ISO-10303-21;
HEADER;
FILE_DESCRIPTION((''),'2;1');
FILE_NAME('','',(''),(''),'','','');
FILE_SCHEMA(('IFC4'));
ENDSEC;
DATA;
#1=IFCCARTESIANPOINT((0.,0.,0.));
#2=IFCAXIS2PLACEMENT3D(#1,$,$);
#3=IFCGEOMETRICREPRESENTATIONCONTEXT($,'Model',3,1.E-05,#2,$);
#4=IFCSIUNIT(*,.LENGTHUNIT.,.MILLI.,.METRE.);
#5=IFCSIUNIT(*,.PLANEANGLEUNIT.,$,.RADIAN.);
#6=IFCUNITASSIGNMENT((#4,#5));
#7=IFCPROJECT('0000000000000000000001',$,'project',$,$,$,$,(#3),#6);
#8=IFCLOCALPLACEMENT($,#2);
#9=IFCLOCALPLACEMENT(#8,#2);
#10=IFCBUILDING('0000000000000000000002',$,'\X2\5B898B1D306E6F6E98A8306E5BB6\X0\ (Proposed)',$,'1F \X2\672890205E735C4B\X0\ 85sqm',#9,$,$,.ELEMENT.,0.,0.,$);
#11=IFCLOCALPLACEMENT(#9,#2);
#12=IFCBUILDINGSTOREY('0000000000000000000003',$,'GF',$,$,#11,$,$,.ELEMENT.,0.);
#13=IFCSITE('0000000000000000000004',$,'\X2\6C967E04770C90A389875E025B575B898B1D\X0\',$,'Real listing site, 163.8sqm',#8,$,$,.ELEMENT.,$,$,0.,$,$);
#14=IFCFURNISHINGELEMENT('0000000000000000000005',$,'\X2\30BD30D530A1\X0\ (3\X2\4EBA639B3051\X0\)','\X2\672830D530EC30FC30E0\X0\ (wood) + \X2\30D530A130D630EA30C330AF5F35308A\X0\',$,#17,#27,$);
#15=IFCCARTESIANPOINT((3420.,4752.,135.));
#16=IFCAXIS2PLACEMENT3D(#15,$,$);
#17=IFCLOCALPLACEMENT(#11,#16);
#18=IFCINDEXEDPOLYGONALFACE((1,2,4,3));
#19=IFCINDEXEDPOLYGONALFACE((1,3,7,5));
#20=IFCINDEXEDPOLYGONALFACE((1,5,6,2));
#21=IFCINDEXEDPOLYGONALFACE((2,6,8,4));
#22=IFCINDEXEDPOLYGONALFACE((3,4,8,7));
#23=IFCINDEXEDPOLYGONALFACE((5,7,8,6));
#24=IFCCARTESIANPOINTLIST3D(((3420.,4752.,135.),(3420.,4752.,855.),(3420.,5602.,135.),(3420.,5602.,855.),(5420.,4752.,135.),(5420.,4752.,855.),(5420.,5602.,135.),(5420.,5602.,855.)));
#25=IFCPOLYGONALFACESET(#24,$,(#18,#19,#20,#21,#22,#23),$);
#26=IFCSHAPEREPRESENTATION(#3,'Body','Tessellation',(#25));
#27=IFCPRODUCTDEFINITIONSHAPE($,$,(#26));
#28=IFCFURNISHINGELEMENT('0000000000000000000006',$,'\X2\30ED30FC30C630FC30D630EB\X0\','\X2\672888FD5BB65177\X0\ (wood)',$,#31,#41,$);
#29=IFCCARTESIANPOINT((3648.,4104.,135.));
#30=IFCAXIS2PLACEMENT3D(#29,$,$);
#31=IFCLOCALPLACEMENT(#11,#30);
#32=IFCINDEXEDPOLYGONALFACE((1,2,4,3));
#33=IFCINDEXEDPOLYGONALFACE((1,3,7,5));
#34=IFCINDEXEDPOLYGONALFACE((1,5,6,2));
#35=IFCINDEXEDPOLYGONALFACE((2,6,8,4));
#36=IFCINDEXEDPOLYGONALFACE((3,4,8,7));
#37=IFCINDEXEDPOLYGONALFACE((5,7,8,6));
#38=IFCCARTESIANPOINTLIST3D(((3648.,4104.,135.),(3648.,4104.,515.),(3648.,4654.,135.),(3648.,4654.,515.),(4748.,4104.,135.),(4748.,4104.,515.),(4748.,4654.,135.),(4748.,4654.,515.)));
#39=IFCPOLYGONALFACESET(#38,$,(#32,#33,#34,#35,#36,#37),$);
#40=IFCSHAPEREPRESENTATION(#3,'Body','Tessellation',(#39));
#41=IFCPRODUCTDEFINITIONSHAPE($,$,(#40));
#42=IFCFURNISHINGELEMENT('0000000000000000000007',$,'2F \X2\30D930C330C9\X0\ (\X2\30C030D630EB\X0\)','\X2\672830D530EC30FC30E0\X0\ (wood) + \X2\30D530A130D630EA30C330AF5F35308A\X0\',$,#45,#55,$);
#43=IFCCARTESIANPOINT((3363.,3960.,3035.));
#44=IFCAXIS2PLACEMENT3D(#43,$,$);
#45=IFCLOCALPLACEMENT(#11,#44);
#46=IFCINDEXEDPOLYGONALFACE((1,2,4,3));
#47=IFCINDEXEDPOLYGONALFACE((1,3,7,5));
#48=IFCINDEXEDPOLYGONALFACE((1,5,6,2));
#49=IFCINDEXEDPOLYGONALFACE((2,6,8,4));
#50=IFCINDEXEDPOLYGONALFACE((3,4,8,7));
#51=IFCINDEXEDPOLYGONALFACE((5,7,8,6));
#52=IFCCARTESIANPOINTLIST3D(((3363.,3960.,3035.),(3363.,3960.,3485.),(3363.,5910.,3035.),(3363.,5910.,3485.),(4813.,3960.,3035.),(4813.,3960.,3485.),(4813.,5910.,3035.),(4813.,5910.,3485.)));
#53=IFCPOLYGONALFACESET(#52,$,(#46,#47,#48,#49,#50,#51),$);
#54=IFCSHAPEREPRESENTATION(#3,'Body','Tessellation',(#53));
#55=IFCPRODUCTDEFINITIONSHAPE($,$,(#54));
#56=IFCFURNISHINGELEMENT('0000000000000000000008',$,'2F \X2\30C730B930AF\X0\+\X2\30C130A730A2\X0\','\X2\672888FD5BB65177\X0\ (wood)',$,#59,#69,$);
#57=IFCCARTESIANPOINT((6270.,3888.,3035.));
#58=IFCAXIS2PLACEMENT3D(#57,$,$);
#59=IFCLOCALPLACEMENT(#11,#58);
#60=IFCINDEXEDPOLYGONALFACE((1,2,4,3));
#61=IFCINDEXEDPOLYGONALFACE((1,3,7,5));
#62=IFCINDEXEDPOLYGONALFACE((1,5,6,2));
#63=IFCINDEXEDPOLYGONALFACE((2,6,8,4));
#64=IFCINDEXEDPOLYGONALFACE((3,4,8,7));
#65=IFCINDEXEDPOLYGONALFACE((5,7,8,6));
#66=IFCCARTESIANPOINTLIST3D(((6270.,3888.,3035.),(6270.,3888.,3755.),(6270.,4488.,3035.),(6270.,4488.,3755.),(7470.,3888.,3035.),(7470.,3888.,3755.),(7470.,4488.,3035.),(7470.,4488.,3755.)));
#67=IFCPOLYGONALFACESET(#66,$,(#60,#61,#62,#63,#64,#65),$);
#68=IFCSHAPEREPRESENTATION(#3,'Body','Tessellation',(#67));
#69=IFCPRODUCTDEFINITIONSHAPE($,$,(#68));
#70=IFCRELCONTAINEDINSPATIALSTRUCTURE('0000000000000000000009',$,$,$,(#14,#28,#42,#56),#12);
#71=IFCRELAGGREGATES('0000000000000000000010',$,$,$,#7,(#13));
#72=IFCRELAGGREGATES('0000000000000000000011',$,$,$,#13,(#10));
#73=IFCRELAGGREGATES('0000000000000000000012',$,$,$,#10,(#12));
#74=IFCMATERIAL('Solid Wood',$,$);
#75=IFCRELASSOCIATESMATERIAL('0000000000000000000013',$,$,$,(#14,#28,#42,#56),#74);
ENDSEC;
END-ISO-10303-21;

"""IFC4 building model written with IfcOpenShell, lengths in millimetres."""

from ifc_helpers import new_model, si_unit, frame, frame_2d, origin, place, context, project, spatial, rectangle, extrude, material, element, save


model = new_model("IFC4")

# Units and contexts
model_context = context("Model", 3, precision=1e-05, world=origin())
ifc_project = project(units=[si_unit("LENGTHUNIT", "METRE", prefix="MILLI"), si_unit("PLANEANGLEUNIT", "RADIAN")], contexts=[model_context])

# Site, building, storey
site_placement = place(None, origin())
site = spatial("IfcSite", under=ifc_project, at=site_placement, Name="沖縄県那覇市字安謝", ObjectType="Real listing site, 163.8sqm", CompositionType="ELEMENT", RefElevation=0.0)
building_placement = place(site_placement, origin())
building = spatial("IfcBuilding", under=site, at=building_placement, Name="安謝の潮風の家 (Proposed)", ObjectType="1F 木造平屋 85sqm", CompositionType="ELEMENT", ElevationOfRefHeight=0.0, ElevationOfTerrain=0.0)
storey_placement = place(building_placement, origin())
storey = spatial("IfcBuildingStorey", under=building, at=storey_placement, Name="GF", CompositionType="ELEMENT", Elevation=0.0)

# Shared definitions
ifc_material_1 = material(Name="Solid Wood")

# Furnishing elements
furnishing_1_placement = place(storey_placement, frame((3420.0, 4752.0, 135.0)))
element("IfcFurnishingElement", 1, at=furnishing_1_placement, inside=storey, material=ifc_material_1, Name="ソファ (3人掛け)", Description="木フレーム (wood) + ファブリック張り", context=model_context, shape_type="SweptSolid", body=[
    extrude(rectangle(XDim=2000.0, YDim=850.0, at=frame_2d((1000.0, 425.0))), frame((3420.0, 4752.0, 135.0)), (0.0, 0.0, 1.0), 720.0),
])
furnishing_2_placement = place(storey_placement, frame((3648.0, 4104.0, 135.0)))
element("IfcFurnishingElement", 2, at=furnishing_2_placement, inside=storey, material=ifc_material_1, Name="ローテーブル", Description="木製家具 (wood)", context=model_context, shape_type="SweptSolid", body=[
    extrude(rectangle(XDim=1100.0, YDim=550.0, at=frame_2d((550.0, 275.0))), frame((3648.0, 4104.0, 135.0)), (0.0, 0.0, 1.0), 380.0),
])
furnishing_3_placement = place(storey_placement, frame((3363.0, 3960.0, 3035.0)))
element("IfcFurnishingElement", 3, at=furnishing_3_placement, inside=storey, material=ifc_material_1, Name="2F ベッド (ダブル)", Description="木フレーム (wood) + ファブリック張り", context=model_context, shape_type="SweptSolid", body=[
    extrude(rectangle(XDim=1450.0, YDim=1950.0, at=frame_2d((725.0, 975.0))), frame((3363.0, 3960.0, 3035.0)), (0.0, 0.0, 1.0), 450.0),
])
furnishing_4_placement = place(storey_placement, frame((6270.0, 3888.0, 3035.0)))
element("IfcFurnishingElement", 4, at=furnishing_4_placement, inside=storey, material=ifc_material_1, Name="2F デスク+チェア", Description="木製家具 (wood)", context=model_context, shape_type="SweptSolid", body=[
    extrude(rectangle(XDim=1200.0, YDim=600.0, at=frame_2d((600.0, 300.0))), frame((6270.0, 3888.0, 3035.0)), (0.0, 0.0, 1.0), 720.0),
])

save(model, "model.ifc")
